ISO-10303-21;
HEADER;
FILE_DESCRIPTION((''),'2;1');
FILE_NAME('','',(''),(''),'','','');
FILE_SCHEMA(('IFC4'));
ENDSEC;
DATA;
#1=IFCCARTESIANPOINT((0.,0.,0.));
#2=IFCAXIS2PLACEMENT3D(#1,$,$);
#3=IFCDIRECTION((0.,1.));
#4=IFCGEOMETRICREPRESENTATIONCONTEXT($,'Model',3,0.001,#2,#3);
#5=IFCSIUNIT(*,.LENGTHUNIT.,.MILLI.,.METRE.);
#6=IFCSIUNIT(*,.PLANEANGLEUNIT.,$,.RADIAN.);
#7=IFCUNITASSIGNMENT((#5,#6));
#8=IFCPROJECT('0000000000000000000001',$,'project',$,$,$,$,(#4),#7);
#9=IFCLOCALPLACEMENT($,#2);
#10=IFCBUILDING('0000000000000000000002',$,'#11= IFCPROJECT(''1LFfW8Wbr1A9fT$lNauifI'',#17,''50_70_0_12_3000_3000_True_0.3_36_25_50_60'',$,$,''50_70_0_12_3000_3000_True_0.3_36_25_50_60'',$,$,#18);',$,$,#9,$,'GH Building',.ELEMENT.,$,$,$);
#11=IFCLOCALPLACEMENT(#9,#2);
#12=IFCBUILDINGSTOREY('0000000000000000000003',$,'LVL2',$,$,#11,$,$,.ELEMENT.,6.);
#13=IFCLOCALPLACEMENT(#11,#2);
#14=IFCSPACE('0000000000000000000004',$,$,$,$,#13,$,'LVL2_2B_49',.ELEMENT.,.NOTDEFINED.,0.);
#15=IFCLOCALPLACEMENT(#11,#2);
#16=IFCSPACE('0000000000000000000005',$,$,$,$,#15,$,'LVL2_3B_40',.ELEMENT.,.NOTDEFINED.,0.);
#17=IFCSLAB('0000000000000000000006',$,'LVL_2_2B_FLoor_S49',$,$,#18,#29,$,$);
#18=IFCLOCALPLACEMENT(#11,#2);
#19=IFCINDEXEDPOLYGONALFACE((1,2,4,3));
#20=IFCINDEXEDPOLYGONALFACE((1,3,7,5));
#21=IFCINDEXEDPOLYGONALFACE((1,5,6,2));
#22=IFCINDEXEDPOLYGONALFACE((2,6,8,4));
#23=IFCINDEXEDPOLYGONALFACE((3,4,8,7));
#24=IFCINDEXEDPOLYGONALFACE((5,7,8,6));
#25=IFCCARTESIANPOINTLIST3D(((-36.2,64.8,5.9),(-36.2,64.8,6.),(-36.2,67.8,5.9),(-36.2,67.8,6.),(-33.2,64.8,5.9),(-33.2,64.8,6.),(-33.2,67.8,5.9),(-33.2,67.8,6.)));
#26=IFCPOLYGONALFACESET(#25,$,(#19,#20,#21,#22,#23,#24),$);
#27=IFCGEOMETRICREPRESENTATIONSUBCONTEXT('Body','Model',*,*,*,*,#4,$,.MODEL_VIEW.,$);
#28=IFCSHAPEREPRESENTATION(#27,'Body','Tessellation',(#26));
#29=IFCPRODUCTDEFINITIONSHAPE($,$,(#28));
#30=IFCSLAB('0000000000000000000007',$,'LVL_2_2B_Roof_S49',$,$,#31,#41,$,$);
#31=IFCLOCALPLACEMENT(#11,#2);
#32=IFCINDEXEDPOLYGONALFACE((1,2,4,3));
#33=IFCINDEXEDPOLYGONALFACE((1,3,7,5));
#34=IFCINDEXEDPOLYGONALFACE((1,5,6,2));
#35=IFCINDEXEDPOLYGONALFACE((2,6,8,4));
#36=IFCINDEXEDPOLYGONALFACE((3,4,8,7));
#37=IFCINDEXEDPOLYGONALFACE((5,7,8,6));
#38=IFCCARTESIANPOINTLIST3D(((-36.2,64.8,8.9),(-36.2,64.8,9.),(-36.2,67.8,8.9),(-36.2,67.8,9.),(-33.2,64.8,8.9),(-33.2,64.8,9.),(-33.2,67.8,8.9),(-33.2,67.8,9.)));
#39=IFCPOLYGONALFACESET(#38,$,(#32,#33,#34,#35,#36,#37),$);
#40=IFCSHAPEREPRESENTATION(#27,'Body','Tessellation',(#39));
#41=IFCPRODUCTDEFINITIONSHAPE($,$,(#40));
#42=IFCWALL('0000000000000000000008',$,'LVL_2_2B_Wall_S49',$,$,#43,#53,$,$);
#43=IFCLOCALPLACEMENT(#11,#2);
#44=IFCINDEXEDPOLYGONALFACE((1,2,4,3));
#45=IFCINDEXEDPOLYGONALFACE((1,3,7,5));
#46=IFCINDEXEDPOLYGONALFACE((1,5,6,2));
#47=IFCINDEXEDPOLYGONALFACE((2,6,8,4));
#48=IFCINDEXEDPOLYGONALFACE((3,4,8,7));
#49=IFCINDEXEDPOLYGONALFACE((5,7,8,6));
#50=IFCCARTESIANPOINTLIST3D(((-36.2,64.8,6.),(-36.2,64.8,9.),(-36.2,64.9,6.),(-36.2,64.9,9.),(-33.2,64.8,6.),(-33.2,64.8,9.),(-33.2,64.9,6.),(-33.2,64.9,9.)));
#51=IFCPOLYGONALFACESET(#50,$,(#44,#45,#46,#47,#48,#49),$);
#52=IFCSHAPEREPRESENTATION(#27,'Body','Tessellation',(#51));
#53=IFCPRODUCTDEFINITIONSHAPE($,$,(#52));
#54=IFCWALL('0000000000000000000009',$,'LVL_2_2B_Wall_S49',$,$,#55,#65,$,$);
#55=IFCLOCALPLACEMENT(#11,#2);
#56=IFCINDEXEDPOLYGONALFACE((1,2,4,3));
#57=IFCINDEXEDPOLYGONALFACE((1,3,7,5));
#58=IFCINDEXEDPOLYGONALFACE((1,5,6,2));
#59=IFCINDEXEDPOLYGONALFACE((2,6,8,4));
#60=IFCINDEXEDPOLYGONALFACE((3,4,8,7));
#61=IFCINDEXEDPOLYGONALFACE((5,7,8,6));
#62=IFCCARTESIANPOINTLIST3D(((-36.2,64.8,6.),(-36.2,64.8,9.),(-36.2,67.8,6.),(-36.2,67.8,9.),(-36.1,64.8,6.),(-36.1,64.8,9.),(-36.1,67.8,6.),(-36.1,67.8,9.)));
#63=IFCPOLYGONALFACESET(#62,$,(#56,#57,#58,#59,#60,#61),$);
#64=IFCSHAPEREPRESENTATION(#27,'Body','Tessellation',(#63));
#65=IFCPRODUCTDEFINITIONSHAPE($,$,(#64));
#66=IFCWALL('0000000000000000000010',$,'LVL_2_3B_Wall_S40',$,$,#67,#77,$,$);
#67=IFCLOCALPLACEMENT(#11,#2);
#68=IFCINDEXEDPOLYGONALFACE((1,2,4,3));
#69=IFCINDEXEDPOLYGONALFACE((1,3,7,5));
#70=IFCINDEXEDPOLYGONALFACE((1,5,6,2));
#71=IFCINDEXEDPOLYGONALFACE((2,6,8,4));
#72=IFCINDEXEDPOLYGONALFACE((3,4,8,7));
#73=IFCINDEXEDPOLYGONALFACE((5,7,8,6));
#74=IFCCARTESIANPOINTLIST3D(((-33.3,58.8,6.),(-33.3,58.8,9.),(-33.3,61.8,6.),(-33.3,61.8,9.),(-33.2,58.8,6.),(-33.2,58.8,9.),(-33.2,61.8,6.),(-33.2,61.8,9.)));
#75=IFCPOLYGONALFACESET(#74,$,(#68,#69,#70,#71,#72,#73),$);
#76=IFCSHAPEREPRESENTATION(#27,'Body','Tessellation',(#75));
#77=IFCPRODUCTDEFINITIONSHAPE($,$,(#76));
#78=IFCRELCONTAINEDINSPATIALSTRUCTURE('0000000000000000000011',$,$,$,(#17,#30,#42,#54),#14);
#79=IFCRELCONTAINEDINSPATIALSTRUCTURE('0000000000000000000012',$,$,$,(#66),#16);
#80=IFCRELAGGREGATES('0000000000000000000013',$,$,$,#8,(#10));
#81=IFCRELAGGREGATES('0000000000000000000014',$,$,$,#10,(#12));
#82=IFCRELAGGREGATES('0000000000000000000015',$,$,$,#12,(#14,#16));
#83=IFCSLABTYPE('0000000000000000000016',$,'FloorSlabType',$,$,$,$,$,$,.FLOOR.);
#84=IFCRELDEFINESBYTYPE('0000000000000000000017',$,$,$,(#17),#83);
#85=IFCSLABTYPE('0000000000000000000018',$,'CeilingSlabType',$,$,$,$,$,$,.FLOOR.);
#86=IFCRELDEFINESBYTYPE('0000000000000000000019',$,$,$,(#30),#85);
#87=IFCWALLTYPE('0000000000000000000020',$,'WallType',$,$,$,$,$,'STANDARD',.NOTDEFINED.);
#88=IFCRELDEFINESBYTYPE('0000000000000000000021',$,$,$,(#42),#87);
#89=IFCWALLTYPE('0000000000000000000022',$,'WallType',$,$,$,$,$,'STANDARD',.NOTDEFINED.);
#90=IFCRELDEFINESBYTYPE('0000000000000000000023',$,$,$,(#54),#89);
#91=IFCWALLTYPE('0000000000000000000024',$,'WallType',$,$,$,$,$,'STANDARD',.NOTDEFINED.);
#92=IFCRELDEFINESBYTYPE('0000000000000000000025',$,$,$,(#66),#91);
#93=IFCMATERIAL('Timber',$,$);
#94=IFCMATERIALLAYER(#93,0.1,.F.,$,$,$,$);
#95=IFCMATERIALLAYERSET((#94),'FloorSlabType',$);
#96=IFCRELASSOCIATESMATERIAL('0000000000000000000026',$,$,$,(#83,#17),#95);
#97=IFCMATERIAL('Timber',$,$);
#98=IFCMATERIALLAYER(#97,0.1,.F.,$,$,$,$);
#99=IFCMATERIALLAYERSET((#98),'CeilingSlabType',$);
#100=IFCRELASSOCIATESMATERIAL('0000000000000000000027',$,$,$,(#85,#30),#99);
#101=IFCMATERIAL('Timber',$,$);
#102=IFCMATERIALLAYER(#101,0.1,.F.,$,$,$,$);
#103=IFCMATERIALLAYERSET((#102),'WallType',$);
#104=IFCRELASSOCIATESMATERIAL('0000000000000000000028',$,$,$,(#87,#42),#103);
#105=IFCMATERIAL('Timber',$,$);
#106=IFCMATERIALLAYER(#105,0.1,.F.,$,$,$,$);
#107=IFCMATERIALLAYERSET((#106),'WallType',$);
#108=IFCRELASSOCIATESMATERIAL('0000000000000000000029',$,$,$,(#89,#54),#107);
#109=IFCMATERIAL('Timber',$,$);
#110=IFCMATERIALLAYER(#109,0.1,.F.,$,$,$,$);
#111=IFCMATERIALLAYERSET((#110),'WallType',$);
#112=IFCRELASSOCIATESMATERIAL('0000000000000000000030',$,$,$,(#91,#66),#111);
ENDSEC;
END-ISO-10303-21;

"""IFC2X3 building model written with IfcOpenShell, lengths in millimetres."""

from ifc_helpers import new_model, si_unit, direction, frame, frame_2d, origin, place, context, subcontext, project, spatial, rectangle, extrude, material, layer, layer_set, layer_usage, type_object, element, save


model = new_model("IFC2X3")

# Units and contexts
model_context = context("Model", 3, precision=0.001, world=origin(), true_north=direction((0.0, 1.0)))
body_context = subcontext(model_context, "Body", "Model", "MODEL_VIEW")
ifc_project = project(units=[si_unit("LENGTHUNIT", "METRE", prefix="MILLI"), si_unit("PLANEANGLEUNIT", "RADIAN")], contexts=[model_context])

# Building, storey
building_placement = place(None, origin())
building = spatial("IfcBuilding", under=ifc_project, at=building_placement, Name="#11= IFCPROJECT('1LFfW8Wbr1A9fT$lNauifI',#17,'50_70_0_12_3000_3000_True_0.3_36_25_50_60',$,$,'50_70_0_12_3000_3000_True_0.3_36_25_50_60',$,$,#18);", LongName="GH Building", CompositionType="ELEMENT")
storey_placement = place(building_placement, origin())
storey = spatial("IfcBuildingStorey", under=building, at=storey_placement, Name="LVL2", CompositionType="ELEMENT", Elevation=6.0)

# Shared definitions
space_1_placement = place(storey_placement, origin())
space_1 = spatial("IfcSpace", under=storey, at=space_1_placement, LongName="LVL2_2B_49", CompositionType="ELEMENT", InteriorOrExteriorSpace="NOTDEFINED", ElevationWithFlooring=0.0)

# Slabs
ifc_material_1 = material(Name="Timber")
ifc_layer_1 = layer(ifc_material_1, 0.1, ventilated=False)
ifc_layer_set_1 = layer_set([ifc_layer_1], Name="FloorSlabType")
ifc_layer_usage_1 = layer_usage(ifc_layer_set_1, "AXIS3", "NEGATIVE", -0.1)
slab_type_1 = type_object("IfcSlabType", Name="FloorSlabType", PredefinedType="FLOOR", material=ifc_layer_set_1)
slab_1_placement = place(space_1_placement, frame((-33.2, 67.8, 5.9), z_axis=(0.0, 0.0, 1.0), x_axis=(-1.0, 0.0, 0.0)))
element("IfcSlab", 1, at=slab_1_placement, inside=space_1, type_object=slab_type_1, material=ifc_layer_usage_1, Name="LVL_2_2B_FLoor_S49", context=body_context, shape_type="SweptSolid", body=[
    extrude(rectangle(XDim=3.0, YDim=3.0, at=frame_2d((1.5, 1.5))), origin(), (0.0, 0.0, 1.0), 0.1),
])
ifc_material_2 = material(Name="Timber")
ifc_layer_2 = layer(ifc_material_2, 0.1, ventilated=False)
ifc_layer_set_2 = layer_set([ifc_layer_2], Name="CeilingSlabType")
ifc_layer_usage_2 = layer_usage(ifc_layer_set_2, "AXIS3", "NEGATIVE", -0.1)
slab_type_2 = type_object("IfcSlabType", Name="CeilingSlabType", PredefinedType="FLOOR", material=ifc_layer_set_2)
slab_2_placement = place(space_1_placement, frame((-33.2, 67.8, 8.9), z_axis=(0.0, 0.0, 1.0), x_axis=(-1.0, 0.0, 0.0)))
element("IfcSlab", 2, at=slab_2_placement, inside=space_1, type_object=slab_type_2, material=ifc_layer_usage_2, Name="LVL_2_2B_Roof_S49", context=body_context, shape_type="SweptSolid", body=[
    extrude(rectangle(XDim=3.0, YDim=3.0, at=frame_2d((1.5, 1.5))), origin(), (0.0, 0.0, 1.0), 0.1),
])

# Walls
ifc_material_3 = material(Name="Timber")
ifc_layer_3 = layer(ifc_material_3, 0.1, ventilated=False)
ifc_layer_set_3 = layer_set([ifc_layer_3], Name="WallType")
ifc_layer_usage_3 = layer_usage(ifc_layer_set_3, "AXIS2", "NEGATIVE", 0.0)
wall_type_1 = type_object("IfcWallType", Name="WallType", ElementType="STANDARD", PredefinedType="NOTDEFINED", material=ifc_layer_set_3)
wall_1_placement = place(space_1_placement, frame((-33.2, 64.8, 6.0), z_axis=(0.0, 0.0, 1.0), x_axis=(-1.0, 0.0, 0.0)))
element("IfcWall", 3, at=wall_1_placement, inside=space_1, type_object=wall_type_1, material=ifc_layer_usage_3, Name="LVL_2_2B_Wall_S49", context=body_context, shape_type="SweptSolid", body=[
    extrude(rectangle(XDim=3.0, YDim=0.1, at=frame_2d((1.5, -0.1))), origin(), (0.0, 0.0, 1.0), 3.0),
])
ifc_material_4 = material(Name="Timber")
ifc_layer_4 = layer(ifc_material_4, 0.1, ventilated=False)
ifc_layer_set_4 = layer_set([ifc_layer_4], Name="WallType")
ifc_layer_usage_4 = layer_usage(ifc_layer_set_4, "AXIS2", "NEGATIVE", 0.0)
wall_type_2 = type_object("IfcWallType", Name="WallType", ElementType="STANDARD", PredefinedType="NOTDEFINED", material=ifc_layer_set_4)
wall_2_placement = place(space_1_placement, frame((-36.2, 64.8, 6.0), z_axis=(0.0, 0.0, 1.0), x_axis=(0.0, 1.0, 0.0)))
element("IfcWall", 4, at=wall_2_placement, inside=space_1, type_object=wall_type_2, material=ifc_layer_usage_4, Name="LVL_2_2B_Wall_S49", context=body_context, shape_type="SweptSolid", body=[
    extrude(rectangle(XDim=3.0, YDim=0.1, at=frame_2d((1.5, -0.1))), origin(), (0.0, 0.0, 1.0), 3.0),
])

# Shared definitions
space_2_placement = place(storey_placement, origin())
space_2 = spatial("IfcSpace", under=storey, at=space_2_placement, LongName="LVL2_3B_40", CompositionType="ELEMENT", InteriorOrExteriorSpace="NOTDEFINED", ElevationWithFlooring=0.0)

# Wall
ifc_material_5 = material(Name="Timber")
ifc_layer_5 = layer(ifc_material_5, 0.1, ventilated=False)
ifc_layer_set_5 = layer_set([ifc_layer_5], Name="WallType")
ifc_layer_usage_5 = layer_usage(ifc_layer_set_5, "AXIS2", "NEGATIVE", 0.0)
wall_type_3 = type_object("IfcWallType", Name="WallType", ElementType="STANDARD", PredefinedType="NOTDEFINED", material=ifc_layer_set_5)
wall_3_placement = place(space_2_placement, frame((-33.2, 61.8, 6.0), z_axis=(0.0, 0.0, 1.0), x_axis=(0.0, -1.0, 0.0)))
element("IfcWall", 5, at=wall_3_placement, inside=space_2, type_object=wall_type_3, material=ifc_layer_usage_5, Name="LVL_2_3B_Wall_S40", context=body_context, shape_type="SweptSolid", body=[
    extrude(rectangle(XDim=3.0, YDim=0.1, at=frame_2d((1.5, -0.1))), origin(), (0.0, 0.0, 1.0), 3.0),
])

save(model, "model.ifc")
